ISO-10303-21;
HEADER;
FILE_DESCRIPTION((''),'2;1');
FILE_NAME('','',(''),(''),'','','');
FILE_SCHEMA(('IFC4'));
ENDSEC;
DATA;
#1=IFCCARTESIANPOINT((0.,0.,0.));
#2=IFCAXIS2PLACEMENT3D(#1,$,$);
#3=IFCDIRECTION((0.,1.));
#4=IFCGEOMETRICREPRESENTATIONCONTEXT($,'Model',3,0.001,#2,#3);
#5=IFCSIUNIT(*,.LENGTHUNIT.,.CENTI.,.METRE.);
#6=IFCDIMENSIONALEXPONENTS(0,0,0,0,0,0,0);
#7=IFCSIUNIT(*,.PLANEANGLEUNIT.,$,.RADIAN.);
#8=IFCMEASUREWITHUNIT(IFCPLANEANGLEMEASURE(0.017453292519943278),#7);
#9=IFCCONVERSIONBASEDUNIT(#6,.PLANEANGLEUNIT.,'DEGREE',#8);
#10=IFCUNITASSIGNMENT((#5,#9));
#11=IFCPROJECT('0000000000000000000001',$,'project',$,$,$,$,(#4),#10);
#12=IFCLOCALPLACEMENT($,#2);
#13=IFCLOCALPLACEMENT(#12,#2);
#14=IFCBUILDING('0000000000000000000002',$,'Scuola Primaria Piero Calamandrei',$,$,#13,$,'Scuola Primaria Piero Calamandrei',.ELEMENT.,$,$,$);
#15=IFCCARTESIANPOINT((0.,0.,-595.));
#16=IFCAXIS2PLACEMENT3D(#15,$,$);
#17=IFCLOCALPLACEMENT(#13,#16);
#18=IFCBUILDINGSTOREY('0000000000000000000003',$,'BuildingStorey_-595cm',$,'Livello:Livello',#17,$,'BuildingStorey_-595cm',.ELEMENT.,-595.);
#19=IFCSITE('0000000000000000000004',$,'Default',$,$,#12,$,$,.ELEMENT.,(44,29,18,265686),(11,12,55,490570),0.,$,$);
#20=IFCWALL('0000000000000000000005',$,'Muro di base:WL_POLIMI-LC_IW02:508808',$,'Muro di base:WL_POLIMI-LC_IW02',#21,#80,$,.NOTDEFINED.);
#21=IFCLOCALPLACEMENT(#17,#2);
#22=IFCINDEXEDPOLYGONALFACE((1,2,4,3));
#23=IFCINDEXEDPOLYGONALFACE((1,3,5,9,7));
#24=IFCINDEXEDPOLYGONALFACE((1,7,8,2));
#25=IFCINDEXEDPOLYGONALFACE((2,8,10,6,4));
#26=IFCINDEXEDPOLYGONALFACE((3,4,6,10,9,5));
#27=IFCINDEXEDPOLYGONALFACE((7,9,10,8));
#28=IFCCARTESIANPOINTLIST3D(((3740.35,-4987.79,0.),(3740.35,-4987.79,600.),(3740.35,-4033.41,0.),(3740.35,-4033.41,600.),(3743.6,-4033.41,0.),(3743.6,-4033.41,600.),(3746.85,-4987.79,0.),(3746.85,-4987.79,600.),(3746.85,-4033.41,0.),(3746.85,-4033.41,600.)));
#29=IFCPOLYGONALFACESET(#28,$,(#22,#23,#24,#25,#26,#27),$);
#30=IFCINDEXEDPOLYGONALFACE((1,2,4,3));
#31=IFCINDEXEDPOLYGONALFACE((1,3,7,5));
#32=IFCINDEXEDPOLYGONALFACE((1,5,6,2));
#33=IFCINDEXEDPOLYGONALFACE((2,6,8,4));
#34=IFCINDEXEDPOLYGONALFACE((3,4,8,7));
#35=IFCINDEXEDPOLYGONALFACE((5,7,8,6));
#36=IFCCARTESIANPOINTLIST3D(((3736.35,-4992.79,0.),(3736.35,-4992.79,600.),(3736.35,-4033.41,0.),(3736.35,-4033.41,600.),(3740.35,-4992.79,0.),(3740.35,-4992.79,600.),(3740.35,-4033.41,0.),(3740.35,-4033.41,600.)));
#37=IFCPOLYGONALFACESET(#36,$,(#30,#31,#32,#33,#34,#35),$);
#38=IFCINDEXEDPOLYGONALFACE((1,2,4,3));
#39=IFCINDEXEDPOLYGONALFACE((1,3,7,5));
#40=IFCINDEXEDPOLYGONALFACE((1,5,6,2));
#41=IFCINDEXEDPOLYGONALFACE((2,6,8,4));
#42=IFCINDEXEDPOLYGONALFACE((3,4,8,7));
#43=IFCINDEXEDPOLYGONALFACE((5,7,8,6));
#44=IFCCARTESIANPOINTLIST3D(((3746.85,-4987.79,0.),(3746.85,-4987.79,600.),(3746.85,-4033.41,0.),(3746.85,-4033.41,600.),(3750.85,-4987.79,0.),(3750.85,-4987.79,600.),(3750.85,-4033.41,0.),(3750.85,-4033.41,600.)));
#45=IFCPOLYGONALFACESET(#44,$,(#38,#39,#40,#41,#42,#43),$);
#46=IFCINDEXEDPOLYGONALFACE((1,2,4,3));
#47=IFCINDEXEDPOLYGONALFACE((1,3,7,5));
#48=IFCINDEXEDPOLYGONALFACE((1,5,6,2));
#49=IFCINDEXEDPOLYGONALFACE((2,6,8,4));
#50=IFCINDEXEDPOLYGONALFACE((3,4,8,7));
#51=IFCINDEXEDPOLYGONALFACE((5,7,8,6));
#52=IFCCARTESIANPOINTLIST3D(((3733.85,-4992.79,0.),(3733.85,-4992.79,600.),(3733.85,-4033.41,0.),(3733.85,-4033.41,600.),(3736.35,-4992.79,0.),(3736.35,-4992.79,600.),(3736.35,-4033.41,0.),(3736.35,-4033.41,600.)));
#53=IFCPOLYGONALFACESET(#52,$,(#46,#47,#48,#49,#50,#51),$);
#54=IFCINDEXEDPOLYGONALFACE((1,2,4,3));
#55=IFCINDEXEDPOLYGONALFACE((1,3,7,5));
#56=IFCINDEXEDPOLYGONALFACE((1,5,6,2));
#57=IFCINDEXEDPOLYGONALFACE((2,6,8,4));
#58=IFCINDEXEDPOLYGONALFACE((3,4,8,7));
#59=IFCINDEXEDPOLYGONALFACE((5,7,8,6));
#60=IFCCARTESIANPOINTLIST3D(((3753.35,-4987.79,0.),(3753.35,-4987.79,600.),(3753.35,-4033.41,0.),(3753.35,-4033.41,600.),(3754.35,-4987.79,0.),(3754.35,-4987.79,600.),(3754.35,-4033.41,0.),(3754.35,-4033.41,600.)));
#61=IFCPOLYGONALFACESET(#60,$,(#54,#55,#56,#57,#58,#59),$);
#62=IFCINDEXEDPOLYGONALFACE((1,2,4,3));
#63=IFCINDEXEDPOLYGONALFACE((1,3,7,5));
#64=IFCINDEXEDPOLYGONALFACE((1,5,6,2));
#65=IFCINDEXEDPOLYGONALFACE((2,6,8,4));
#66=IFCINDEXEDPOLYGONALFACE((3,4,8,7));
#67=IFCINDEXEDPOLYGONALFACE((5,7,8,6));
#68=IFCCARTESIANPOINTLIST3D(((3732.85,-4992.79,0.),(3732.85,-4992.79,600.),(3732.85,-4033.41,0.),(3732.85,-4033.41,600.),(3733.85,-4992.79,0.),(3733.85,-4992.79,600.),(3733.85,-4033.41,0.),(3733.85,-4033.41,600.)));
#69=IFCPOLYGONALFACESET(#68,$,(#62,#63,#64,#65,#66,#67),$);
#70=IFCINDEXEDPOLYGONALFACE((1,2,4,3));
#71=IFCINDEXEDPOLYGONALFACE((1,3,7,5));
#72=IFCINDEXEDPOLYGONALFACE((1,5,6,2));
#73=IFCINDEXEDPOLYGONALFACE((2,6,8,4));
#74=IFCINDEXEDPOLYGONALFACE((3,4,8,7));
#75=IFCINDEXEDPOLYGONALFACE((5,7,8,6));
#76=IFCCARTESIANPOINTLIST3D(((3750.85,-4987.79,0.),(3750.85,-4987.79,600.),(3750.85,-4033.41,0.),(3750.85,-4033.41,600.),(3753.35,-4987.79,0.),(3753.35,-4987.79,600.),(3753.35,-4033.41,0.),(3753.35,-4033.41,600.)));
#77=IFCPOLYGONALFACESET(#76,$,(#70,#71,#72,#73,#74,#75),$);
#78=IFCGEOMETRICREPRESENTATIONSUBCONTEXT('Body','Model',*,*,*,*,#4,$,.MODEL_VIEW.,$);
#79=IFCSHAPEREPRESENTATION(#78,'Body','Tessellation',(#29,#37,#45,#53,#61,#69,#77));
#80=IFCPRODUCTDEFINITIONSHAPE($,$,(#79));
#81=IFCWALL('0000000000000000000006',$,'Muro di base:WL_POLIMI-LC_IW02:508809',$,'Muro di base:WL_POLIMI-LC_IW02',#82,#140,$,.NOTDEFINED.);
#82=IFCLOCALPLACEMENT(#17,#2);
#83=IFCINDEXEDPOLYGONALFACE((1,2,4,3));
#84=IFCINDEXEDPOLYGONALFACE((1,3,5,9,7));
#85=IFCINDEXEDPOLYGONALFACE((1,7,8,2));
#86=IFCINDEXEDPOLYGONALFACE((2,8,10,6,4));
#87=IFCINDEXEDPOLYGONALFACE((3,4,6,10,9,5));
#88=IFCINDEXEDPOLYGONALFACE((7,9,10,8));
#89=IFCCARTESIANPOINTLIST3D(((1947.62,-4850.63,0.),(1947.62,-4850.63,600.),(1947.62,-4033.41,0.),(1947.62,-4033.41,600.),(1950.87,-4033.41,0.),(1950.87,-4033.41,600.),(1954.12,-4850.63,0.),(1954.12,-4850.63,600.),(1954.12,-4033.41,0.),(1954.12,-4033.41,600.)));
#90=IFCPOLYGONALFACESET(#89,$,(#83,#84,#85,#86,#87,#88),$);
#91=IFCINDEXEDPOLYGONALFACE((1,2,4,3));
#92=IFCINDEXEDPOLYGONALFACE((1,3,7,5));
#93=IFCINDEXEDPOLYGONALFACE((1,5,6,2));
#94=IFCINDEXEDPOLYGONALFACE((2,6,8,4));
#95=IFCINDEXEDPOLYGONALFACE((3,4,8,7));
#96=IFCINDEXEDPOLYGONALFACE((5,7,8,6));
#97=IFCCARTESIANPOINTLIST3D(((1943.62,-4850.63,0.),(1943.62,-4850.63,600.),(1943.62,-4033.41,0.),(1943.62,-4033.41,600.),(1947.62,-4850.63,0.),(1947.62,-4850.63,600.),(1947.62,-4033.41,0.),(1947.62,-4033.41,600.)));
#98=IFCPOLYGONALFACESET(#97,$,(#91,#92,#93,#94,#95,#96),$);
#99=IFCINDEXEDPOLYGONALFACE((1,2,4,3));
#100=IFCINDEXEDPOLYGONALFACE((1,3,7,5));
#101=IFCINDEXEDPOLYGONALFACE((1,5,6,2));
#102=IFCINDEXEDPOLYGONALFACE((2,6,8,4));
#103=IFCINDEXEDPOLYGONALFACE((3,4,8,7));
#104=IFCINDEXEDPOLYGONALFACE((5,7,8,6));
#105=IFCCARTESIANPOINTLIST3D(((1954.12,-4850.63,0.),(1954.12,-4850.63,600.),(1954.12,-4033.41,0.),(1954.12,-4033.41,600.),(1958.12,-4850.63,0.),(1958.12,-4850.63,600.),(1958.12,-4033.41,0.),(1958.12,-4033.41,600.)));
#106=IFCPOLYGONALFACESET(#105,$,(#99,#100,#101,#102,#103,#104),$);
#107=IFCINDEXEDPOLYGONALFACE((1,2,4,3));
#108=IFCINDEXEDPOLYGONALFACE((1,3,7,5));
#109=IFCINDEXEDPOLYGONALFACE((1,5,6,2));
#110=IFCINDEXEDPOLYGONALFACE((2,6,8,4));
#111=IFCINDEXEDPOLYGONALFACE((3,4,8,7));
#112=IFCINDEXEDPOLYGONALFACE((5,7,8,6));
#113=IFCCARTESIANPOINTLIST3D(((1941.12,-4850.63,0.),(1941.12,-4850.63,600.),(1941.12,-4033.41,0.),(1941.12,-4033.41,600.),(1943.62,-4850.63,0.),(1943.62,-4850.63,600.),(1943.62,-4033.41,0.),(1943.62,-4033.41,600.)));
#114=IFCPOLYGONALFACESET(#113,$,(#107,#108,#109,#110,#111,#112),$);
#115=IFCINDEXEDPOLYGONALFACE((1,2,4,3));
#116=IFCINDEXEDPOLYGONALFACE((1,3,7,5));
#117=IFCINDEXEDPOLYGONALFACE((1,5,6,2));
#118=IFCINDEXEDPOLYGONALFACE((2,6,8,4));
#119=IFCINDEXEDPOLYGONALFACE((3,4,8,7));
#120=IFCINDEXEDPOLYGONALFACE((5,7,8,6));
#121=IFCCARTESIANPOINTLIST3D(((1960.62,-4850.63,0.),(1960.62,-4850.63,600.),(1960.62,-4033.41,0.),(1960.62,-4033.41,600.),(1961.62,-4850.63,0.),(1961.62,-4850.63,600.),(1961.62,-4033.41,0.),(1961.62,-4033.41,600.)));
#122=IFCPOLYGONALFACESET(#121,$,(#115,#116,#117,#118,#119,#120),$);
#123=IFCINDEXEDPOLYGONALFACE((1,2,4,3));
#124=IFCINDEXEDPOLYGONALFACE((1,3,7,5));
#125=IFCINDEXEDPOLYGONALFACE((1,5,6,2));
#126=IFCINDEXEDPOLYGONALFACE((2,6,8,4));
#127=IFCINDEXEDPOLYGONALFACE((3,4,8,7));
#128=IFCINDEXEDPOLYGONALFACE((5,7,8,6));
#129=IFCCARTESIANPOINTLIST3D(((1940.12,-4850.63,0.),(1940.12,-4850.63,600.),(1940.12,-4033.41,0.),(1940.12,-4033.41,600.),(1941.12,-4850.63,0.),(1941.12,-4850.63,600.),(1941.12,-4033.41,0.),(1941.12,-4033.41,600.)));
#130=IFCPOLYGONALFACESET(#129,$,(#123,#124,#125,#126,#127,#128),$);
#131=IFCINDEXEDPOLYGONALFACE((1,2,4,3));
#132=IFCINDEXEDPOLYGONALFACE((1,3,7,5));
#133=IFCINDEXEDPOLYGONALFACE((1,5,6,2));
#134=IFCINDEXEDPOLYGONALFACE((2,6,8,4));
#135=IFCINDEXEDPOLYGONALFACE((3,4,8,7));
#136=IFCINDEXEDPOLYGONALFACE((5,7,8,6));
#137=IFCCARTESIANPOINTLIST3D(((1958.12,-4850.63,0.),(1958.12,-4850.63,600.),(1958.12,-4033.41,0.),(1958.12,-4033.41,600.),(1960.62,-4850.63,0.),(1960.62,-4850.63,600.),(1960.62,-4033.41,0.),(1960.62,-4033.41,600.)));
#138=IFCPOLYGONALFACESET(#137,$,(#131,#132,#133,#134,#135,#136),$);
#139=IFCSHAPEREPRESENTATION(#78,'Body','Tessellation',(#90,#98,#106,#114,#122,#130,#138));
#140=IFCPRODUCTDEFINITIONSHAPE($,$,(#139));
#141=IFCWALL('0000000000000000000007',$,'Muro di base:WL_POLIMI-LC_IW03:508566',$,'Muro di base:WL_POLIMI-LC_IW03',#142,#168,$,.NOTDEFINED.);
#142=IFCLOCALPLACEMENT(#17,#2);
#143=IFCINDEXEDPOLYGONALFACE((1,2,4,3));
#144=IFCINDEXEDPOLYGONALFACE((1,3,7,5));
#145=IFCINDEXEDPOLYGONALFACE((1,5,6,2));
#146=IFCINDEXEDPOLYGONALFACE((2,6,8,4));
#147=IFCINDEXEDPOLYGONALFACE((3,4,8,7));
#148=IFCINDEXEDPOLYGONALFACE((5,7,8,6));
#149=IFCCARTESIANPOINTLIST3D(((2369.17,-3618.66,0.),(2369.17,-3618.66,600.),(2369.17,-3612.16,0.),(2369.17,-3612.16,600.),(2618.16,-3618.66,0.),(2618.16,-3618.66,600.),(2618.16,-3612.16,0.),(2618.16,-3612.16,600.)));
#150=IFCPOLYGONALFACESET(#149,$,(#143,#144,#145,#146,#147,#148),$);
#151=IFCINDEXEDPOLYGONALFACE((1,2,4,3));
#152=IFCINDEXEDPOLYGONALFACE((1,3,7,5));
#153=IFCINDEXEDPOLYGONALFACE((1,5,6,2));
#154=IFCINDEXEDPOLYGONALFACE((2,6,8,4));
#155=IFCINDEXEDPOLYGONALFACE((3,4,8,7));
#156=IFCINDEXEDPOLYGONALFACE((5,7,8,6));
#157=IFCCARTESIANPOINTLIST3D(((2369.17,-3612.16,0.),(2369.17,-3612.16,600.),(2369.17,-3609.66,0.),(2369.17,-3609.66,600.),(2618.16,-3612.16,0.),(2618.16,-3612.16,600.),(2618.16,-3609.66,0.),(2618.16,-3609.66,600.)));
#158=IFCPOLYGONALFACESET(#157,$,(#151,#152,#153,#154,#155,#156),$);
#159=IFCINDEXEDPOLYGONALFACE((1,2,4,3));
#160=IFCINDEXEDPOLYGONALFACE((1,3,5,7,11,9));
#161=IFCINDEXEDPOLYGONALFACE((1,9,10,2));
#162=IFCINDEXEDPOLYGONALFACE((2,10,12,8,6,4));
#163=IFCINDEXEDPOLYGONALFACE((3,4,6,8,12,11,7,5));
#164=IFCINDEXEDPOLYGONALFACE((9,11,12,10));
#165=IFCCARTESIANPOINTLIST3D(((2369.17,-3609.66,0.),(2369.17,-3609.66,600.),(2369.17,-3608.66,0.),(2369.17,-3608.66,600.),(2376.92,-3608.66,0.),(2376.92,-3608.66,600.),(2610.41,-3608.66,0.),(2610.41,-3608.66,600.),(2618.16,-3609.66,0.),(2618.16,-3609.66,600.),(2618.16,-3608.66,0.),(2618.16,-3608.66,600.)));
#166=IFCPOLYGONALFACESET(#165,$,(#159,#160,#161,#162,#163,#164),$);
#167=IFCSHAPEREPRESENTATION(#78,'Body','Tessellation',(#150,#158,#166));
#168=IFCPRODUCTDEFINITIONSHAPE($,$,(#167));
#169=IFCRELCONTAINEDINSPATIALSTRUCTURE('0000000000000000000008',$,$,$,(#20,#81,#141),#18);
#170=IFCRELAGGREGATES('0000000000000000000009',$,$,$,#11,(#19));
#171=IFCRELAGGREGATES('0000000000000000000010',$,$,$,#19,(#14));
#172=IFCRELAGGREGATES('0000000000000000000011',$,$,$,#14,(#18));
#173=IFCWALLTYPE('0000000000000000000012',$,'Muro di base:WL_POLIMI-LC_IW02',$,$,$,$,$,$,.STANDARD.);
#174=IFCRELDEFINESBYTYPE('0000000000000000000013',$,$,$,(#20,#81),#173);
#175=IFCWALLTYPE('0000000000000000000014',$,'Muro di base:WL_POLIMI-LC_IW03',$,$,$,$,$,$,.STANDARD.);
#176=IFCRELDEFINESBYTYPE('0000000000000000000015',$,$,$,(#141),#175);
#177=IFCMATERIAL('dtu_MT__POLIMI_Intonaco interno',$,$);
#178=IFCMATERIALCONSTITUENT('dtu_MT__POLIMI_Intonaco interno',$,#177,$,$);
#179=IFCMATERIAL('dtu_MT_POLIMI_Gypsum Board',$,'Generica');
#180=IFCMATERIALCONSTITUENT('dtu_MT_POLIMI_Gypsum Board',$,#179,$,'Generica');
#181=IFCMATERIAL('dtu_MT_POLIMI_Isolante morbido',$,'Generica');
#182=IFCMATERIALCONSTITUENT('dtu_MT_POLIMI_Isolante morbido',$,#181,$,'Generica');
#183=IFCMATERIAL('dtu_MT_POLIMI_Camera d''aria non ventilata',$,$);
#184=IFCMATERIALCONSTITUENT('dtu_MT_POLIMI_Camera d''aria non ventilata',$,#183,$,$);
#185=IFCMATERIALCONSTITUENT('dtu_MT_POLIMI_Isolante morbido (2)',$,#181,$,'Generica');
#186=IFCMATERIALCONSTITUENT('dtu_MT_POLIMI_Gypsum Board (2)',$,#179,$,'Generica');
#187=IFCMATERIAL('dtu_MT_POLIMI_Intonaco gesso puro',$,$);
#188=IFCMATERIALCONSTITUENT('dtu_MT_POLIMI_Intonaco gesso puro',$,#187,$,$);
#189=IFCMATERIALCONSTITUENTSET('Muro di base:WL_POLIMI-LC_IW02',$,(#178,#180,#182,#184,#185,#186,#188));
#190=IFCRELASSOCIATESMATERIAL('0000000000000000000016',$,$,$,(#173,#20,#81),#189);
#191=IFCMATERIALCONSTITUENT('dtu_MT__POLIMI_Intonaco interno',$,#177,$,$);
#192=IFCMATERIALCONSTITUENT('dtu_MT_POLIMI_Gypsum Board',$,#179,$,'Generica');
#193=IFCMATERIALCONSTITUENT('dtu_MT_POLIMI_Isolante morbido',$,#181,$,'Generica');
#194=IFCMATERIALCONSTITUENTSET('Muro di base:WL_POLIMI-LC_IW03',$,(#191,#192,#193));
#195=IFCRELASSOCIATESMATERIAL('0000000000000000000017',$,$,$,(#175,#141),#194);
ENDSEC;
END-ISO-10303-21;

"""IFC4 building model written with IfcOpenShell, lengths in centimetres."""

from ifc_helpers import new_model, entity, si_unit, converted_unit, direction, frame, origin, place, context, subcontext, project, spatial, indexed_curve, outline, extrude, material, constituent, constituent_set, type_object, element, save


model = new_model("IFC4")

# Units and contexts
model_context = context("Model", 3, precision=0.001, world=origin(), true_north=direction((0.0, 1.0)))
body_context = subcontext(model_context, "Body", "Model", "MODEL_VIEW")
ifc_project = project(units=[si_unit("LENGTHUNIT", "METRE", prefix="CENTI"), converted_unit("PLANEANGLEUNIT", "DEGREE", entity("IfcPlaneAngleMeasure", 0.017453292519943278), si_unit("PLANEANGLEUNIT", "RADIAN"), dimensions=[0, 0, 0, 0, 0, 0, 0])], contexts=[model_context])

# Site, building, storey
site_placement = place(None, origin())
site = spatial("IfcSite", under=ifc_project, at=site_placement, Name="Default", CompositionType="ELEMENT", RefLatitude=(44, 29, 18, 265686), RefLongitude=(11, 12, 55, 490570), RefElevation=0.0)
building_placement = place(site_placement, origin())
building = spatial("IfcBuilding", under=site, at=building_placement, Name="Scuola Primaria Piero Calamandrei", LongName="Scuola Primaria Piero Calamandrei", CompositionType="ELEMENT")
storey_placement = place(building_placement, frame((0.0, 0.0, -595.0)))
storey = spatial("IfcBuildingStorey", under=building, at=storey_placement, Name="BuildingStorey_-595cm", ObjectType="Livello:Livello", LongName="BuildingStorey_-595cm", CompositionType="ELEMENT", Elevation=-595.0)

# Shared definitions
ifc_material_1 = material(Name="dtu_MT__POLIMI_Intonaco interno")
ifc_constituent_1 = constituent(ifc_material_1, Name="dtu_MT__POLIMI_Intonaco interno")
ifc_material_2 = material(Name="dtu_MT_POLIMI_Gypsum Board", Category="Generica")
ifc_constituent_2 = constituent(ifc_material_2, Name="dtu_MT_POLIMI_Gypsum Board", Category="Generica")
ifc_material_3 = material(Name="dtu_MT_POLIMI_Isolante morbido", Category="Generica")
ifc_constituent_3 = constituent(ifc_material_3, Name="dtu_MT_POLIMI_Isolante morbido", Category="Generica")
ifc_material_4 = material(Name="dtu_MT_POLIMI_Camera d'aria non ventilata")
ifc_constituent_4 = constituent(ifc_material_4, Name="dtu_MT_POLIMI_Camera d'aria non ventilata")
ifc_constituent_5 = constituent(ifc_material_3, Name="dtu_MT_POLIMI_Isolante morbido (2)", Category="Generica")
ifc_constituent_6 = constituent(ifc_material_2, Name="dtu_MT_POLIMI_Gypsum Board (2)", Category="Generica")
ifc_material_5 = material(Name="dtu_MT_POLIMI_Intonaco gesso puro")
ifc_constituent_7 = constituent(ifc_material_5, Name="dtu_MT_POLIMI_Intonaco gesso puro")
ifc_constituent_set_1 = constituent_set(constituents=[ifc_constituent_1, ifc_constituent_2, ifc_constituent_3, ifc_constituent_4, ifc_constituent_5, ifc_constituent_6, ifc_constituent_7], Name="Muro di base:WL_POLIMI-LC_IW02")
wall_type_1 = type_object("IfcWallType", Name="Muro di base:WL_POLIMI-LC_IW02", PredefinedType="STANDARD", material=ifc_constituent_set_1)

# Walls
wall_1_placement = place(storey_placement, frame((3743.6, -4987.79, 0.0), z_axis=(0.0, 0.0, 1.0), x_axis=(0.0, 1.0, 0.0)))
element("IfcWall", 1, at=wall_1_placement, inside=storey, type_object=wall_type_1, material=ifc_constituent_set_1, Name="Muro di base:WL_POLIMI-LC_IW02:508808", ObjectType="Muro di base:WL_POLIMI-LC_IW02", PredefinedType="NOTDEFINED", context=body_context, shape_type="SweptSolid", body=[
    extrude(outline(indexed_curve([(-572.63, -3.25), (381.75, -3.25), (381.75, 0.0), (381.75, 3.25), (-572.63, 3.25), (-572.63, -3.25)], self_intersect=False)), frame((572.63, 0.0, 0.0)), (0.0, 0.0, 1.0), 600.0),
    extrude(outline(indexed_curve([(-479.69, -2.0), (479.69, -2.0), (479.69, 2.0), (-479.69, 2.0), (-479.69, -2.0)], self_intersect=False)), frame((474.69, 5.25, 0.0)), (0.0, 0.0, 1.0), 600.0),
    extrude(outline(indexed_curve([(-477.19, -2.0), (477.19, -2.0), (477.19, 2.0), (-477.19, 2.0), (-477.19, -2.0)], self_intersect=False)), frame((477.19, -5.25, 0.0)), (0.0, 0.0, 1.0), 600.0),
    extrude(outline(indexed_curve([(-479.69, -1.25), (479.69, -1.25), (479.69, 1.25), (-479.69, 1.25), (-479.69, -1.25)], self_intersect=False)), frame((474.69, 8.5, 0.0)), (0.0, 0.0, 1.0), 600.0),
    extrude(outline(indexed_curve([(-0.5, -477.19), (0.5, -477.19), (0.5, 477.19), (-0.5, 477.19), (-0.5, -477.19)], self_intersect=False)), frame((477.19, -10.25, 0.0), z_axis=(0.0, 0.0, 1.0), x_axis=(0.0, 1.0, 0.0)), (0.0, 0.0, 1.0), 600.0),
    extrude(outline(indexed_curve([(-0.5, -479.69), (0.5, -479.69), (0.5, 479.69), (-0.5, 479.69), (-0.5, -479.69)], self_intersect=False)), frame((474.69, 10.25, 0.0), z_axis=(0.0, 0.0, 1.0), x_axis=(0.0, -1.0, 0.0)), (0.0, 0.0, 1.0), 600.0),
    extrude(outline(indexed_curve([(-477.19, -1.25), (477.19, -1.25), (477.19, 1.25), (-477.19, 1.25), (-477.19, -1.25)], self_intersect=False)), frame((477.19, -8.5, 0.0)), (0.0, 0.0, 1.0), 600.0),
])
wall_2_placement = place(storey_placement, frame((1950.87, -4850.63, 0.0), z_axis=(0.0, 0.0, 1.0), x_axis=(0.0, 1.0, 0.0)))
element("IfcWall", 2, at=wall_2_placement, inside=storey, type_object=wall_type_1, material=ifc_constituent_set_1, Name="Muro di base:WL_POLIMI-LC_IW02:508809", ObjectType="Muro di base:WL_POLIMI-LC_IW02", PredefinedType="NOTDEFINED", context=body_context, shape_type="SweptSolid", body=[
    extrude(outline(indexed_curve([(-490.33, -3.25), (326.89, -3.25), (326.89, 0.0), (326.89, 3.25), (-490.33, 3.25), (-490.33, -3.25)], self_intersect=False)), frame((490.33, 0.0, 0.0)), (0.0, 0.0, 1.0), 600.0),
    extrude(outline(indexed_curve([(-408.61, -2.0), (408.61, -2.0), (408.61, 2.0), (-408.61, 2.0), (-408.61, -2.0)], self_intersect=False)), frame((408.61, 5.25, 0.0)), (0.0, 0.0, 1.0), 600.0),
    extrude(outline(indexed_curve([(-408.61, -2.0), (408.61, -2.0), (408.61, 2.0), (-408.61, 2.0), (-408.61, -2.0)], self_intersect=False)), frame((408.61, -5.25, 0.0)), (0.0, 0.0, 1.0), 600.0),
    extrude(outline(indexed_curve([(-408.61, -1.25), (408.61, -1.25), (408.61, 1.25), (-408.61, 1.25), (-408.61, -1.25)], self_intersect=False)), frame((408.61, 8.5, 0.0)), (0.0, 0.0, 1.0), 600.0),
    extrude(outline(indexed_curve([(-0.5, -408.61), (0.5, -408.61), (0.5, 408.61), (-0.5, 408.61), (-0.5, -408.61)], self_intersect=False)), frame((408.61, -10.25, 0.0), z_axis=(0.0, 0.0, 1.0), x_axis=(0.0, 1.0, 0.0)), (0.0, 0.0, 1.0), 600.0),
    extrude(outline(indexed_curve([(-0.5, -408.61), (0.5, -408.61), (0.5, 408.61), (-0.5, 408.61), (-0.5, -408.61)], self_intersect=False)), frame((408.61, 10.25, 0.0), z_axis=(0.0, 0.0, 1.0), x_axis=(0.0, -1.0, 0.0)), (0.0, 0.0, 1.0), 600.0),
    extrude(outline(indexed_curve([(-408.61, -1.25), (408.61, -1.25), (408.61, 1.25), (-408.61, 1.25), (-408.61, -1.25)], self_intersect=False)), frame((408.61, -8.5, 0.0)), (0.0, 0.0, 1.0), 600.0),
])
ifc_constituent_8 = constituent(ifc_material_1, Name="dtu_MT__POLIMI_Intonaco interno")
ifc_constituent_9 = constituent(ifc_material_2, Name="dtu_MT_POLIMI_Gypsum Board", Category="Generica")
ifc_constituent_10 = constituent(ifc_material_3, Name="dtu_MT_POLIMI_Isolante morbido", Category="Generica")
ifc_constituent_set_2 = constituent_set(constituents=[ifc_constituent_8, ifc_constituent_9, ifc_constituent_10], Name="Muro di base:WL_POLIMI-LC_IW03")
wall_type_2 = type_object("IfcWallType", Name="Muro di base:WL_POLIMI-LC_IW03", PredefinedType="STANDARD", material=ifc_constituent_set_2)
wall_3_placement = place(storey_placement, frame((2369.17, -3613.66, 0.0)))
element("IfcWall", 3, at=wall_3_placement, inside=storey, type_object=wall_type_2, material=ifc_constituent_set_2, Name="Muro di base:WL_POLIMI-LC_IW03:508566", ObjectType="Muro di base:WL_POLIMI-LC_IW03", PredefinedType="NOTDEFINED", context=body_context, shape_type="SweptSolid", body=[
    extrude(outline(indexed_curve([(-3.25, -124.5), (3.25, -124.5), (3.25, 124.5), (-3.25, 124.5), (-3.25, -124.5)], self_intersect=False)), frame((124.5, -1.75, 0.0), z_axis=(0.0, 0.0, 1.0), x_axis=(0.0, 1.0, 0.0)), (0.0, 0.0, 1.0), 600.0),
    extrude(outline(indexed_curve([(-124.5, -1.25), (124.5, -1.25), (124.5, 1.25), (-124.5, 1.25), (-124.5, -1.25)], self_intersect=False)), frame((124.5, 2.75, 0.0)), (0.0, 0.0, 1.0), 600.0),
    extrude(outline(indexed_curve([(-116.75, -0.33), (116.75, -0.33), (124.5, -0.33), (124.5, 0.67), (-124.5, 0.67), (-124.5, -0.33), (-116.75, -0.33)], self_intersect=False)), frame((124.5, 4.67, 0.0), z_axis=(0.0, 0.0, 1.0), x_axis=(-1.0, 0.0, 0.0)), (0.0, 0.0, 1.0), 600.0),
])

save(model, "model.ifc")
